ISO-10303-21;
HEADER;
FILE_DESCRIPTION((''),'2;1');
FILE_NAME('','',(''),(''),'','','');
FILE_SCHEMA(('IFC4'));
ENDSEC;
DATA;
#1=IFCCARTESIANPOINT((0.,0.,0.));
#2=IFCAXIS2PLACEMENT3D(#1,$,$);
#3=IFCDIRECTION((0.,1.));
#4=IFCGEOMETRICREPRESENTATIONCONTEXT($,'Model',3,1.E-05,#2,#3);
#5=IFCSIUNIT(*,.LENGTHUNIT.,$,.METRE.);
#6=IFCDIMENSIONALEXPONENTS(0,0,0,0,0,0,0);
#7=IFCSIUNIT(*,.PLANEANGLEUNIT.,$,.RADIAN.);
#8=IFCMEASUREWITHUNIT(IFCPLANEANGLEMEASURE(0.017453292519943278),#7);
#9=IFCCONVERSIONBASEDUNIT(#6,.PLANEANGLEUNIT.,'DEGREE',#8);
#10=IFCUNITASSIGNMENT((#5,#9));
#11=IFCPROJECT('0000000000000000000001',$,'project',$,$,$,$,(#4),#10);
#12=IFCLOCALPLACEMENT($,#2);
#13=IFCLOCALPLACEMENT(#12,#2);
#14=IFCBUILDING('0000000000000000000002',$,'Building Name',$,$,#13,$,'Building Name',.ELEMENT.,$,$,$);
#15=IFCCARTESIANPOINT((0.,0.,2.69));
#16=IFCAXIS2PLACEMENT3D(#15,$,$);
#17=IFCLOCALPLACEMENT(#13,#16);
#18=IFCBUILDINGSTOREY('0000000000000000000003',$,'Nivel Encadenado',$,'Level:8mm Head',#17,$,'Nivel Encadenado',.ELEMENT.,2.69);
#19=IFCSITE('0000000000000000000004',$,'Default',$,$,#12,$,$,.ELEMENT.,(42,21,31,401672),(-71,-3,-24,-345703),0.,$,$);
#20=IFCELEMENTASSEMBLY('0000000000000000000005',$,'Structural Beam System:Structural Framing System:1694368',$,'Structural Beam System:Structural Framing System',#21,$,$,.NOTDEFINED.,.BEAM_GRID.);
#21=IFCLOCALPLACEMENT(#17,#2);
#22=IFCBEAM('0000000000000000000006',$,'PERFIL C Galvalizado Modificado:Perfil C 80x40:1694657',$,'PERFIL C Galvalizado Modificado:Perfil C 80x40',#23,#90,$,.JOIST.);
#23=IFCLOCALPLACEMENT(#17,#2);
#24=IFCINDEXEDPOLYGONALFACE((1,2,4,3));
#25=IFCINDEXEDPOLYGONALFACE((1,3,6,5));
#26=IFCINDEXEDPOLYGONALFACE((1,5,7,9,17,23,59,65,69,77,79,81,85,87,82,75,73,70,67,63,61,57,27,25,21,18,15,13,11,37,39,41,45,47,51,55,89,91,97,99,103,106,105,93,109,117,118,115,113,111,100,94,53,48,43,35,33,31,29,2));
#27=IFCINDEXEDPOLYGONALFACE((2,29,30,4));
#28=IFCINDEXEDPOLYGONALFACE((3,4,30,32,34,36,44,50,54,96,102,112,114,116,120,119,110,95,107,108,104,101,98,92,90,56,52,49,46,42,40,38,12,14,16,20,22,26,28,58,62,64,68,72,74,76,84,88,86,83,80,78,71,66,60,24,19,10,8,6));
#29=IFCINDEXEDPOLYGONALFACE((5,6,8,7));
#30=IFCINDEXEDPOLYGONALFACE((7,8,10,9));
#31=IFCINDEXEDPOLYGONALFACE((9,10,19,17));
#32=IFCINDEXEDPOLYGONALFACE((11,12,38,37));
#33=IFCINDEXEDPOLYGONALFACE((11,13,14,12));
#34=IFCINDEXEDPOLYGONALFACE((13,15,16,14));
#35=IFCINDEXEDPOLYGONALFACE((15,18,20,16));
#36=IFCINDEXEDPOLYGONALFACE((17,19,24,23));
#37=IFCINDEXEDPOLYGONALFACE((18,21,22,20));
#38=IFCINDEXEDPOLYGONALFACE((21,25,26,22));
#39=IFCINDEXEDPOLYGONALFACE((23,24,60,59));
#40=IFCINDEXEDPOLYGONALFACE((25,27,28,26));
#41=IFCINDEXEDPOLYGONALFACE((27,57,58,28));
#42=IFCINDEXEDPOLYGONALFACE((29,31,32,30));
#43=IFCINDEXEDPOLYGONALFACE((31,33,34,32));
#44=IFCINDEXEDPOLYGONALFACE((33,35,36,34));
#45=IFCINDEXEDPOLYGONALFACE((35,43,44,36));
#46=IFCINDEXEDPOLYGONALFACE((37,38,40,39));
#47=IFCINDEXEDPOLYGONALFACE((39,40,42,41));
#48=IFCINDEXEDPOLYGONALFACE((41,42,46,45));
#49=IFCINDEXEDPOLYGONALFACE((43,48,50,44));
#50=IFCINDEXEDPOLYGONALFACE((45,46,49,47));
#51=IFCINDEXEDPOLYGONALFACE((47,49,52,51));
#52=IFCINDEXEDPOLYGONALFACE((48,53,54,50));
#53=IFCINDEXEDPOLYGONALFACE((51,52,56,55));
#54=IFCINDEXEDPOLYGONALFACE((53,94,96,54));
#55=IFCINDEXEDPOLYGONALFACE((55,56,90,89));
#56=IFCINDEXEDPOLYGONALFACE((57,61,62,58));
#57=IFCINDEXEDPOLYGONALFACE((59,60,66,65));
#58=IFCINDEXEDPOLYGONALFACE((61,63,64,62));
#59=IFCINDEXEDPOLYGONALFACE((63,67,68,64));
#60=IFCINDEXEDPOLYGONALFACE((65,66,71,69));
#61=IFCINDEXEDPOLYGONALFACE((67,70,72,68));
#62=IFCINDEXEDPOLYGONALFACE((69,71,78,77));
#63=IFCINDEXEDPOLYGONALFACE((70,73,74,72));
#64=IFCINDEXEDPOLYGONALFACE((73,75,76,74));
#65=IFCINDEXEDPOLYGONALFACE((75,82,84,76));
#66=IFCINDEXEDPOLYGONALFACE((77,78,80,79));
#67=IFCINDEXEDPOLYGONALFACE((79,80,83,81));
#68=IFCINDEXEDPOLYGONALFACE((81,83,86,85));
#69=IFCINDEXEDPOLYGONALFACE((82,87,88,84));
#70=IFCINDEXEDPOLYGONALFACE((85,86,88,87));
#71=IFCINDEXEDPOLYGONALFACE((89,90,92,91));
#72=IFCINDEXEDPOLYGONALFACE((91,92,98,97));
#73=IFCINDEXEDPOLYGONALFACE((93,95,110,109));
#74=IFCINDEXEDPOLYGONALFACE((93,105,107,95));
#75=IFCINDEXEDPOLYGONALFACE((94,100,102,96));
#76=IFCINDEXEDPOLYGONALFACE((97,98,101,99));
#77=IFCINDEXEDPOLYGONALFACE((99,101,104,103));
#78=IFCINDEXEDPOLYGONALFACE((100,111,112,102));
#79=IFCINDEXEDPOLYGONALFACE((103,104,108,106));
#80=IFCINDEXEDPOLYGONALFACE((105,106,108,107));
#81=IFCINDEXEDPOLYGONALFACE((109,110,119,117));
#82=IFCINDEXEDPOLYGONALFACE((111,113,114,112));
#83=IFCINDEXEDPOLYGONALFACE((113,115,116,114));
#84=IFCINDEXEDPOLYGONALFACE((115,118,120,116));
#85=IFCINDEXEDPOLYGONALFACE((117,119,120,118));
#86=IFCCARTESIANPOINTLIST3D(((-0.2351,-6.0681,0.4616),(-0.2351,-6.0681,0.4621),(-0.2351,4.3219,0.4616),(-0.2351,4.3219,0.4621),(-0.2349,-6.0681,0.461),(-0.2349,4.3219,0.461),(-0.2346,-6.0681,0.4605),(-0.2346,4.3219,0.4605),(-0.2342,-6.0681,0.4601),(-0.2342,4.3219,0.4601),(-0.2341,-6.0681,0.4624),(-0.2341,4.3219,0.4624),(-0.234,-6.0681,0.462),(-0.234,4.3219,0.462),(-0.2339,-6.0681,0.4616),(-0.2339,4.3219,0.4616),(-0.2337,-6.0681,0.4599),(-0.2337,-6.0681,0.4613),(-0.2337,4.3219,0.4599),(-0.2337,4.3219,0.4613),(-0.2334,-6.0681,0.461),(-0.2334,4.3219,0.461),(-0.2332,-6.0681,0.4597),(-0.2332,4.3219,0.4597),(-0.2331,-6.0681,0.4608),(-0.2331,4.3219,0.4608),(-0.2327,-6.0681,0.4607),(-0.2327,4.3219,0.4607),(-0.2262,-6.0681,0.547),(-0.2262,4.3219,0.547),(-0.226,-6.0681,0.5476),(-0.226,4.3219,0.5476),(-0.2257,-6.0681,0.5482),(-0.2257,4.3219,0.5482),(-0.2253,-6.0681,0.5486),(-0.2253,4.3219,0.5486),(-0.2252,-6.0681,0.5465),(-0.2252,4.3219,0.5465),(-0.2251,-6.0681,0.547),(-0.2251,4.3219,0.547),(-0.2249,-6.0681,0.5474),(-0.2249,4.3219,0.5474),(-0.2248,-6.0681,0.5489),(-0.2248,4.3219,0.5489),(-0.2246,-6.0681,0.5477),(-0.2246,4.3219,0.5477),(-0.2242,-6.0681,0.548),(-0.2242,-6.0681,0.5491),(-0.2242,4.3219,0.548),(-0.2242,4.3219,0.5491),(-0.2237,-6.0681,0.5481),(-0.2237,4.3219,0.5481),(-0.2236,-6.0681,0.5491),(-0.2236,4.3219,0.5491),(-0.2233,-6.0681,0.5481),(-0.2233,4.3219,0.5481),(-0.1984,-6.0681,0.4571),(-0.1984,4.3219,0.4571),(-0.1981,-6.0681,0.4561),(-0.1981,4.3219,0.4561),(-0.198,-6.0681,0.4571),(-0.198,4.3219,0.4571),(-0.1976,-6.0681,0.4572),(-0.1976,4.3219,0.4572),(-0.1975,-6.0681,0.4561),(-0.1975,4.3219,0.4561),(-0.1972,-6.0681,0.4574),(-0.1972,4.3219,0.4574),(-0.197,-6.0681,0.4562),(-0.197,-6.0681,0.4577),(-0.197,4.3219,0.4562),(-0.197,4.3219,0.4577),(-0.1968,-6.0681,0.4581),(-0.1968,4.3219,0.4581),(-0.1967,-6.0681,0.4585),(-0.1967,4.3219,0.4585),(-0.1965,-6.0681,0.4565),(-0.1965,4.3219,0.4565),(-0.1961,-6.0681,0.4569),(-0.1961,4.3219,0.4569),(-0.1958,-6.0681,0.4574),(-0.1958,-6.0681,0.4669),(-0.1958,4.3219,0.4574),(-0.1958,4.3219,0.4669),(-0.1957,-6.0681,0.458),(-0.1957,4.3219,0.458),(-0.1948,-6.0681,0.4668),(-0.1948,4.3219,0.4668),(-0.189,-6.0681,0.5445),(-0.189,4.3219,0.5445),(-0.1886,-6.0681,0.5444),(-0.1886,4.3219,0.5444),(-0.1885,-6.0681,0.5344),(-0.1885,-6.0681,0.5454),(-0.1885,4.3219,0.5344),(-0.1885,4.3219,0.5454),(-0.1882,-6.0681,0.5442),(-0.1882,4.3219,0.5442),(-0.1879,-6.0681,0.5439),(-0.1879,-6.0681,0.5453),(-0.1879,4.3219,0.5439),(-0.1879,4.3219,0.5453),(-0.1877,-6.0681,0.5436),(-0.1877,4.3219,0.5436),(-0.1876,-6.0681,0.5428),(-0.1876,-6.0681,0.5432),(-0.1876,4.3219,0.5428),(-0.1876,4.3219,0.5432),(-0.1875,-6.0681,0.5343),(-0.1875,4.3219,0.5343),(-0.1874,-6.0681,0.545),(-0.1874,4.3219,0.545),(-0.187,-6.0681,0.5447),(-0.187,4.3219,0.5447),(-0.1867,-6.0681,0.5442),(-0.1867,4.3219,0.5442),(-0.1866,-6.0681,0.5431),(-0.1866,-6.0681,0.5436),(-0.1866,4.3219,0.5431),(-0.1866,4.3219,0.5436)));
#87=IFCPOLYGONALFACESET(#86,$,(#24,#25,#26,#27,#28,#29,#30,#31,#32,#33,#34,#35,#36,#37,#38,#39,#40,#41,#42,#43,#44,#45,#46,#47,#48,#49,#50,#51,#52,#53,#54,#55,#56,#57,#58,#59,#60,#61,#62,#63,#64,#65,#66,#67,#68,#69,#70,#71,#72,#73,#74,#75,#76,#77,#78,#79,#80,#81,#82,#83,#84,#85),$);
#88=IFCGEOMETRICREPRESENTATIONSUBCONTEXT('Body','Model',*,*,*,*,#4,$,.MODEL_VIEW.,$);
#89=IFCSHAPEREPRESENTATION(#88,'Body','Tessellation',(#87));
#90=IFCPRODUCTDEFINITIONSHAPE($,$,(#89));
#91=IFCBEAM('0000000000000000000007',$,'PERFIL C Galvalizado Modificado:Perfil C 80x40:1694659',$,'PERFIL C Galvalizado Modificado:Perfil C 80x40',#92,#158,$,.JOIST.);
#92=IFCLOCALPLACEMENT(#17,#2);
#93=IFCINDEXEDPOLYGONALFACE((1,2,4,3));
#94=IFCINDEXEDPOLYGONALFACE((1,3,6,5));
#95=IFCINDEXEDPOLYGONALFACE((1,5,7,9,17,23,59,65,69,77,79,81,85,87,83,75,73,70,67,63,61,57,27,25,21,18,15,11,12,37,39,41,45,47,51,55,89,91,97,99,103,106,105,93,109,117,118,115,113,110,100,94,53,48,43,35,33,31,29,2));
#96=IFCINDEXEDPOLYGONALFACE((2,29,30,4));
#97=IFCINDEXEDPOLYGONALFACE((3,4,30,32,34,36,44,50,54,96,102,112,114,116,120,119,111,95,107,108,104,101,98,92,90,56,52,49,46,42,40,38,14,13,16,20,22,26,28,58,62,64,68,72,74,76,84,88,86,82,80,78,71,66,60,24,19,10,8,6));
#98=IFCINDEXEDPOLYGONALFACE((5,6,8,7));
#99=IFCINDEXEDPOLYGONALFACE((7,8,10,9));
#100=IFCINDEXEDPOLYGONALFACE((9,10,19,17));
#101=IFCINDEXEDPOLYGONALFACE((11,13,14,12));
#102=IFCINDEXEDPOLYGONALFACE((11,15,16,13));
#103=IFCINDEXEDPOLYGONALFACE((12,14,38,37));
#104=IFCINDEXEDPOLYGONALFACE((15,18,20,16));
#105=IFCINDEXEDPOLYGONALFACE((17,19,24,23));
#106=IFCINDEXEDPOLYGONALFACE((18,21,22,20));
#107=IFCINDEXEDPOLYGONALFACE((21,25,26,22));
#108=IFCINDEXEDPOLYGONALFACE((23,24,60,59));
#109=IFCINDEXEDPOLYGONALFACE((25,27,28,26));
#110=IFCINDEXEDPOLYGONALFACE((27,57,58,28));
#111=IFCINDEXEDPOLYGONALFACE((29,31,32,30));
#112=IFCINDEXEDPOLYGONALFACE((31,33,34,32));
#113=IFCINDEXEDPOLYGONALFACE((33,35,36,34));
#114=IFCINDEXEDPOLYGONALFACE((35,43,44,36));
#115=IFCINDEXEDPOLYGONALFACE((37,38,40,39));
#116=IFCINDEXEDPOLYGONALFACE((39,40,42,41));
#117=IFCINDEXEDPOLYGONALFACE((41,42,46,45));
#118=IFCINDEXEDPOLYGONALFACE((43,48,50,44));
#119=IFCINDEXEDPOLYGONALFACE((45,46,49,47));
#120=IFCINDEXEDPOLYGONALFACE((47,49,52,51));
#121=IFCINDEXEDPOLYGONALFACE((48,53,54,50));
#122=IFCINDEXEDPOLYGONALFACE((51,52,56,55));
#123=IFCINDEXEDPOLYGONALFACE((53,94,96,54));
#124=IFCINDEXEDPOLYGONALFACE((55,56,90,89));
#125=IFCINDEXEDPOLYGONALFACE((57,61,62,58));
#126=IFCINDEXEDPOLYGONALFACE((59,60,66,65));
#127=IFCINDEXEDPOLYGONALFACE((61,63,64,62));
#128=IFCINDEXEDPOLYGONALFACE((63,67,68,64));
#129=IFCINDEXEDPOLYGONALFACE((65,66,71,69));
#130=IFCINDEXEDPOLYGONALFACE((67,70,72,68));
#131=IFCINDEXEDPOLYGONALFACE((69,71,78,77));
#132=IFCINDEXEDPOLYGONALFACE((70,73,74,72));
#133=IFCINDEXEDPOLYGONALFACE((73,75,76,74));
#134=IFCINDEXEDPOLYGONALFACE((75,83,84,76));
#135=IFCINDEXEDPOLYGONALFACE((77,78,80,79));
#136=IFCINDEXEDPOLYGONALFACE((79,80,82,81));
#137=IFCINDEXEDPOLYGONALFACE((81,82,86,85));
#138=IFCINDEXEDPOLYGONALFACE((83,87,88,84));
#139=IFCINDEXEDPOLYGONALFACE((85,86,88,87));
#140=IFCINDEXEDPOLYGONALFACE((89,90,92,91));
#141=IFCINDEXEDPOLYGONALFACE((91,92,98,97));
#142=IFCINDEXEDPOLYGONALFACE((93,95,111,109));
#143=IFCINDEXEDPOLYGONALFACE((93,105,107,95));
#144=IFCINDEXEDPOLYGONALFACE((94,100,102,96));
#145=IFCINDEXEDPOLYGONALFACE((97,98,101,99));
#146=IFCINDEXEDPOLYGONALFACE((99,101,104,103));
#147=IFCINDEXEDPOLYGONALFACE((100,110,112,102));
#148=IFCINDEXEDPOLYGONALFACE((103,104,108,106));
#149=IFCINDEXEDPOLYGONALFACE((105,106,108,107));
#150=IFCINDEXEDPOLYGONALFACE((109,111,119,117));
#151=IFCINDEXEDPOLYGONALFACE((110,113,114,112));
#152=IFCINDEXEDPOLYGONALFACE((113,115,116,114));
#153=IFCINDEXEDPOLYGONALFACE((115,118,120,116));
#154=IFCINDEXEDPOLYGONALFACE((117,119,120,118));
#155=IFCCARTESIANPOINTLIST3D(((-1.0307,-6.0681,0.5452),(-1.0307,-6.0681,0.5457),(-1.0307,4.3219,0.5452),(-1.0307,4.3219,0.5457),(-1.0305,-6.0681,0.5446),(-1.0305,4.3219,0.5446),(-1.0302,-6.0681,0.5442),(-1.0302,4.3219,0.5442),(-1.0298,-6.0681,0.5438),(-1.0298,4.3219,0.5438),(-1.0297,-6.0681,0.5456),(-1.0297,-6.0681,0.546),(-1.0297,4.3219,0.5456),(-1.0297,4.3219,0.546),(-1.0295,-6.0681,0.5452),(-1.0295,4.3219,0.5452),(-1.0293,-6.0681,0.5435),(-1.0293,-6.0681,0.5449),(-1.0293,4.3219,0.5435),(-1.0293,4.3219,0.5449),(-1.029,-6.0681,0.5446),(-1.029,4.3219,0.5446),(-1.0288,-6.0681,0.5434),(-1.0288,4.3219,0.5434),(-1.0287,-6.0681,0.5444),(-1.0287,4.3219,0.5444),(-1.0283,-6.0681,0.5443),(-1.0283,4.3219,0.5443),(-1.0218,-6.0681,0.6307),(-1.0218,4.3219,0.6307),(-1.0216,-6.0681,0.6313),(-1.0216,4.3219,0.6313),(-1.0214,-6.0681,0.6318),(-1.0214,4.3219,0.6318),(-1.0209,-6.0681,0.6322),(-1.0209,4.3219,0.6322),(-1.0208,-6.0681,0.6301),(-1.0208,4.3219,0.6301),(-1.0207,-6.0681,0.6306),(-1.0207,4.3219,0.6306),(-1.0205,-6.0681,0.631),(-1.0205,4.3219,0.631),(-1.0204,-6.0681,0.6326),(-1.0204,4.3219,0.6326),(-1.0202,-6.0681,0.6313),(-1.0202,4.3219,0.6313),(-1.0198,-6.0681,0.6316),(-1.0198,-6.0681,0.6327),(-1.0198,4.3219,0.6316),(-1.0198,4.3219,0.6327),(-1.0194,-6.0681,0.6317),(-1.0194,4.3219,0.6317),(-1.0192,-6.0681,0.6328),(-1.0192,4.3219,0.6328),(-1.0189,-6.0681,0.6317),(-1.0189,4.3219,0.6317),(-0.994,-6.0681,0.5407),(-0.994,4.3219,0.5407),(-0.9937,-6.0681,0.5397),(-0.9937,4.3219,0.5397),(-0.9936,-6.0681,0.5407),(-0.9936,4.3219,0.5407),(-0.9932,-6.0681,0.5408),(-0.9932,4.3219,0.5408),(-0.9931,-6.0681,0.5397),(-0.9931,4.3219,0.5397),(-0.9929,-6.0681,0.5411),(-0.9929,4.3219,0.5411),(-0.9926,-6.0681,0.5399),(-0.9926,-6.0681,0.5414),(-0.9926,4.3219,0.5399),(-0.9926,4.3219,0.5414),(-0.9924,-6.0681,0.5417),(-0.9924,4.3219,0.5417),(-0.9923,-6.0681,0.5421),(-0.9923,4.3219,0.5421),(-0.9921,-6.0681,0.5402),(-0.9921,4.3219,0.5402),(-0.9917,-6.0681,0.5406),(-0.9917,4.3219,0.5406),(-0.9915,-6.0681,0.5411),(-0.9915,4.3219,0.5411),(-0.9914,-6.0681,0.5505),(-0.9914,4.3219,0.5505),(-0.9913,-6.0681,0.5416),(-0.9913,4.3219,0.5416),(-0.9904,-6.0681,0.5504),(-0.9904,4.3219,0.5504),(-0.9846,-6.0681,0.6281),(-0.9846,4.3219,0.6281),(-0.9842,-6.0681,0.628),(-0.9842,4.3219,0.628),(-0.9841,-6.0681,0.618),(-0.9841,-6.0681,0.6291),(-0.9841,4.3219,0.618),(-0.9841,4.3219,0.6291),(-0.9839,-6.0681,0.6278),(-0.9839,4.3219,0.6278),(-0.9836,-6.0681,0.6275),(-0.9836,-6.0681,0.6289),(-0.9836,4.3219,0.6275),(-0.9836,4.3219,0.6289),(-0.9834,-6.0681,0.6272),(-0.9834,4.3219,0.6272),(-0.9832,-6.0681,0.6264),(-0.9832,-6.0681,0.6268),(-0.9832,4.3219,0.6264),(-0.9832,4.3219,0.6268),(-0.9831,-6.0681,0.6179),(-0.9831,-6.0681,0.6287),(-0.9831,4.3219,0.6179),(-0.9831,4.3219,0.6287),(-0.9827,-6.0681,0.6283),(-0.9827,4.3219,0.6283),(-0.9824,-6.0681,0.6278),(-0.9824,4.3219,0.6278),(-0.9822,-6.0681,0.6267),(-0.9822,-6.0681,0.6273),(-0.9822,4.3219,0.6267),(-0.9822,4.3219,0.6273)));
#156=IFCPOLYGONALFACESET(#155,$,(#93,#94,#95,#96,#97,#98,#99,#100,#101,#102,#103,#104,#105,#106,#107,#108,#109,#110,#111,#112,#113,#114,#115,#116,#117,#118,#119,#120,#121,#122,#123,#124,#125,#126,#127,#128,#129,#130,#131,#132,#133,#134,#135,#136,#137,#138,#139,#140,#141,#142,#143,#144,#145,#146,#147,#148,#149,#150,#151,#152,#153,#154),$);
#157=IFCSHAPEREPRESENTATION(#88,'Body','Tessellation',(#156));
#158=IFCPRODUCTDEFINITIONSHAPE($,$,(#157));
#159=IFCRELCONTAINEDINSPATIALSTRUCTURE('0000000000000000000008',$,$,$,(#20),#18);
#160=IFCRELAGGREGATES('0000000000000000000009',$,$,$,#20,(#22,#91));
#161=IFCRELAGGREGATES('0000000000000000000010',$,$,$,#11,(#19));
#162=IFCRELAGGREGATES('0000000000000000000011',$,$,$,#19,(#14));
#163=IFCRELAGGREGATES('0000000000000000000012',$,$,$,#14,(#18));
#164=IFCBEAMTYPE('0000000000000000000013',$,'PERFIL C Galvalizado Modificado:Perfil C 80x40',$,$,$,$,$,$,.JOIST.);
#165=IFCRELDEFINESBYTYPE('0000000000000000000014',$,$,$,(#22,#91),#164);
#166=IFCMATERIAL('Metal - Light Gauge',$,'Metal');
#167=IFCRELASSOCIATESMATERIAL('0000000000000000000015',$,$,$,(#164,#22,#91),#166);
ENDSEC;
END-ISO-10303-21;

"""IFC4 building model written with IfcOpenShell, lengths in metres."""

from ifc_helpers import new_model, entity, si_unit, converted_unit, direction, frame, origin, place, context, subcontext, project, spatial, line, arc, indexed_curve, outline, extrude, source, transform, mapped, material, type_object, type_shapes, element, aggregate, save


model = new_model("IFC4")

# Units and contexts
model_context = context("Model", 3, precision=1e-05, world=origin(), true_north=direction((0.0, 1.0)))
body_context = subcontext(model_context, "Body", "Model", "MODEL_VIEW")
ifc_project = project(units=[si_unit("LENGTHUNIT", "METRE"), converted_unit("PLANEANGLEUNIT", "DEGREE", entity("IfcPlaneAngleMeasure", 0.017453292519943278), si_unit("PLANEANGLEUNIT", "RADIAN"), dimensions=[0, 0, 0, 0, 0, 0, 0])], contexts=[model_context])

# Site, building, storey
site_placement = place(None, origin())
site = spatial("IfcSite", under=ifc_project, at=site_placement, Name="Default", CompositionType="ELEMENT", RefLatitude=(42, 21, 31, 401672), RefLongitude=(-71, -3, -24, -345703), RefElevation=0.0)
building_placement = place(site_placement, origin())
building = spatial("IfcBuilding", under=site, at=building_placement, Name="Building Name", LongName="Building Name", CompositionType="ELEMENT")
storey_placement = place(building_placement, frame((0.0, 0.0, 2.69)))
storey = spatial("IfcBuildingStorey", under=building, at=storey_placement, Name="Nivel Encadenado", ObjectType="Level:8mm Head", LongName="Nivel Encadenado", CompositionType="ELEMENT", Elevation=2.69)

# Element assembly, beams
assembly_1_placement = place(storey_placement, origin())
assembly_1 = element("IfcElementAssembly", 1, at=assembly_1_placement, inside=storey, Name="Structural Beam System:Structural Framing System:1694368", ObjectType="Structural Beam System:Structural Framing System", AssemblyPlace="NOTDEFINED", PredefinedType="BEAM_GRID")
ifc_material_1 = material(Name="Metal - Light Gauge", Category="Metal")
beam_type_1 = type_object("IfcBeamType", Name="PERFIL C Galvalizado Modificado:Perfil C 80x40", PredefinedType="JOIST", material=ifc_material_1)
shared_shape_1 = source(origin(), body_context, "Body", "SweptSolid", [
    extrude(outline(indexed_curve([(-0.0428, -0.0237), (0.0426, -0.0237), (0.0443, -0.023), (0.045, -0.0214), (0.045, 0.0139), (0.0443, 0.0154), (0.0428, 0.0161), (0.034, 0.0161), (0.034, 0.0151), (0.0424, 0.0151), (0.0435, 0.0146), (0.044, 0.0135), (0.044, -0.021), (0.0435, -0.0222), (0.0422, -0.0227), (-0.0424, -0.0227), (-0.0435, -0.0223), (-0.0439, -0.0212), (-0.0439, 0.0133), (-0.0435, 0.0144), (-0.0424, 0.0149), (-0.0339, 0.0149), (-0.0339, 0.0159), (-0.0428, 0.0159), (-0.0443, 0.0152), (-0.0449, 0.0137), (-0.0449, -0.0216), (-0.0443, -0.0231)], segments=[line(1, 2), arc(2, 3, 4), line(4, 5), arc(5, 6, 7), line(7, 8, 9, 10), arc(10, 11, 12), line(12, 13), arc(13, 14, 15), line(15, 16), arc(16, 17, 18), line(18, 19), arc(19, 20, 21), line(21, 22, 23, 24), arc(24, 25, 26), line(26, 27), arc(27, 28, 1)], self_intersect=False)), frame((-5.195, -0.0037, 0.0), z_axis=(1.0, 0.0, 0.0), x_axis=(0.0, 0.0, 1.0)), (0.0, 0.0, 1.0), 10.39),
])
type_shapes(beam_type_1, [shared_shape_1])
beam_1_placement = place(assembly_1_placement, frame((-0.2107, -0.8731, 0.5026), z_axis=(0.104528, 0.0, 0.994522), x_axis=(0.0, 1.0, 0.0)))
beam_1 = element("IfcBeam", 2, at=beam_1_placement, type_object=beam_type_1, material=ifc_material_1, Name="PERFIL C Galvalizado Modificado:Perfil C 80x40:1694657", ObjectType="PERFIL C Galvalizado Modificado:Perfil C 80x40", PredefinedType="JOIST", context=body_context, shape_type="MappedRepresentation", body=[
    mapped(shared_shape_1, transform((0.0, 0.0, 0.0), scale=1.0)),
])
beam_2_placement = place(assembly_1_placement, frame((-1.0064, -0.8731, 0.5862), z_axis=(0.104528, 0.0, 0.994522), x_axis=(0.0, 1.0, 0.0)))
beam_2 = element("IfcBeam", 3, at=beam_2_placement, type_object=beam_type_1, material=ifc_material_1, Name="PERFIL C Galvalizado Modificado:Perfil C 80x40:1694659", ObjectType="PERFIL C Galvalizado Modificado:Perfil C 80x40", PredefinedType="JOIST", context=body_context, shape_type="MappedRepresentation", body=[
    mapped(shared_shape_1, transform((0.0, 0.0, 0.0), scale=1.0)),
])
aggregate(assembly_1, [beam_1, beam_2])

save(model, "model.ifc")
